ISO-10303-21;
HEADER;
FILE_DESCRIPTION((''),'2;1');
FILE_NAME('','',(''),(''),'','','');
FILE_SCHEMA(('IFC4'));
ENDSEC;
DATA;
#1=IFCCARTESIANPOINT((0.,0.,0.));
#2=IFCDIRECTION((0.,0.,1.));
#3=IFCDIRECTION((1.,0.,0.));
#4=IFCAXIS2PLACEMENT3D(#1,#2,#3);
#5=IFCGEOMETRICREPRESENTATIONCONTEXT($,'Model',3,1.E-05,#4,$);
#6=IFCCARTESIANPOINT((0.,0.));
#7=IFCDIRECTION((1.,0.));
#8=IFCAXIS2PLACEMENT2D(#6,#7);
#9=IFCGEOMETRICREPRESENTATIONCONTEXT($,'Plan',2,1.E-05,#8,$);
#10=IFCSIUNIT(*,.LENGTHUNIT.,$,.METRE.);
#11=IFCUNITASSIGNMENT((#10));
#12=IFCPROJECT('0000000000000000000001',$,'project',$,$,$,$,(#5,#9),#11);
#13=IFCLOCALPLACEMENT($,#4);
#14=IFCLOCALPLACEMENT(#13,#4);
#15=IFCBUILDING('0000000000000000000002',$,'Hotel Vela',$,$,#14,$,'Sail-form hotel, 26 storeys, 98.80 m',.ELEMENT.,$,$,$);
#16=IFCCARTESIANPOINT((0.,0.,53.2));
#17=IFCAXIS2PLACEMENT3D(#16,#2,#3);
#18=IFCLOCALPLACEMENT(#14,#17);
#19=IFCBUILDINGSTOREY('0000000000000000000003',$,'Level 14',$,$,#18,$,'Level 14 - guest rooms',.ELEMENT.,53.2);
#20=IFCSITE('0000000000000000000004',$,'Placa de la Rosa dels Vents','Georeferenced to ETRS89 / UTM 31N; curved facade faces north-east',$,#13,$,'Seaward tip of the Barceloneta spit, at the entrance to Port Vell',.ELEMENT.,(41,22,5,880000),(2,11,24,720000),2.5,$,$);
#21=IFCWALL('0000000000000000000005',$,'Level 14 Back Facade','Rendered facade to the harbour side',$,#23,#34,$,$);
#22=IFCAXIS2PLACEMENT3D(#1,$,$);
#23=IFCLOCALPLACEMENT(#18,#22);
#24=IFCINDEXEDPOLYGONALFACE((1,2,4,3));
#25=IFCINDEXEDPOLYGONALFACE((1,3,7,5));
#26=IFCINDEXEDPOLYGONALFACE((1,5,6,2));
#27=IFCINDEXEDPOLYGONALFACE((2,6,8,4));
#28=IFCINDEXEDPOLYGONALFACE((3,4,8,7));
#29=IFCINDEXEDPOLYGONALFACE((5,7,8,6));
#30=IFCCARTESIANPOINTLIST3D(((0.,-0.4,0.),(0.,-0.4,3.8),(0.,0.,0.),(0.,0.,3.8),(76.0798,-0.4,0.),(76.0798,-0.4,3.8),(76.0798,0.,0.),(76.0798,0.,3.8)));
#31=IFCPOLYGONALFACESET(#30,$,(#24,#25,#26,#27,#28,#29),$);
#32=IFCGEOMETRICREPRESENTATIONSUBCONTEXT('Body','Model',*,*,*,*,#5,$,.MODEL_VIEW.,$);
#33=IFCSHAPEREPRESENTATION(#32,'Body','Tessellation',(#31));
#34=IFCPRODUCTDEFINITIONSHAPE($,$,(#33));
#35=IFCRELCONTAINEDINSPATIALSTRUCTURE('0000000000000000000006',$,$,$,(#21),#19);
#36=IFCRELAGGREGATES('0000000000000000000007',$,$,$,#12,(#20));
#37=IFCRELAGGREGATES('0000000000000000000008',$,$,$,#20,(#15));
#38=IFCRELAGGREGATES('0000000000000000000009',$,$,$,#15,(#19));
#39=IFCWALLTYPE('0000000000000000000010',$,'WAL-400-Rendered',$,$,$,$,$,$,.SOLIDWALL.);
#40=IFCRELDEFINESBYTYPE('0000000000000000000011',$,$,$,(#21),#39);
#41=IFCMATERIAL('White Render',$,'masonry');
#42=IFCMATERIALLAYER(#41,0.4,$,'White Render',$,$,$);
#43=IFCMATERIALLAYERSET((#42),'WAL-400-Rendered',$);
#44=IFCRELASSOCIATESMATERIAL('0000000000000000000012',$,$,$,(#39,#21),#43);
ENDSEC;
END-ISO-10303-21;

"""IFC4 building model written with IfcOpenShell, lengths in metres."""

from ifc_helpers import new_model, si_unit, frame, origin_with_axes, origin_2d_with_axis, place, context, subcontext, project, spatial, line, indexed_curve, outline, extrude, material, layer, layer_set, layer_usage, type_object, element, save


model = new_model("IFC4")

# Units and contexts
model_context = context("Model", 3, precision=1e-05, world=origin_with_axes())
plan_context = context("Plan", 2, precision=1e-05, world=origin_2d_with_axis())
body_context = subcontext(model_context, "Body", "Model", "MODEL_VIEW")
ifc_project = project(units=[si_unit("LENGTHUNIT", "METRE")], contexts=[model_context, plan_context])

# Site, building, storey
site_placement = place(None, origin_with_axes())
site = spatial("IfcSite", under=ifc_project, at=site_placement, Name="Placa de la Rosa dels Vents", Description="Georeferenced to ETRS89 / UTM 31N; curved facade faces north-east", LongName="Seaward tip of the Barceloneta spit, at the entrance to Port Vell", CompositionType="ELEMENT", RefLatitude=(41, 22, 5, 880000), RefLongitude=(2, 11, 24, 720000), RefElevation=2.5)
building_placement = place(site_placement, origin_with_axes())
building = spatial("IfcBuilding", under=site, at=building_placement, Name="Hotel Vela", LongName="Sail-form hotel, 26 storeys, 98.80 m", CompositionType="ELEMENT")
storey_placement = place(building_placement, frame((0.0, 0.0, 53.2), z_axis=(0.0, 0.0, 1.0), x_axis=(1.0, 0.0, 0.0)))
storey = spatial("IfcBuildingStorey", under=building, at=storey_placement, Name="Level 14", LongName="Level 14 - guest rooms", CompositionType="ELEMENT", Elevation=53.2)

# Wall
ifc_material_1 = material(Name="White Render", Category="masonry")
ifc_layer_1 = layer(ifc_material_1, 0.4, Name="White Render")
ifc_layer_set_1 = layer_set([ifc_layer_1], Name="WAL-400-Rendered")
ifc_layer_usage_1 = layer_usage(ifc_layer_set_1, "AXIS2", "POSITIVE", 0.0)
wall_type = type_object("IfcWallType", Name="WAL-400-Rendered", PredefinedType="SOLIDWALL", material=ifc_layer_set_1)
wall_placement = place(storey_placement, frame((0.0, -0.4, 0.0), z_axis=(0.0, 0.0, 1.0), x_axis=(1.0, 0.0, 0.0)))
element("IfcWall", 1, at=wall_placement, inside=storey, type_object=wall_type, material=ifc_layer_usage_1, Name="Level 14 Back Facade", Description="Rendered facade to the harbour side", context=body_context, shape_type="SweptSolid", body=[
    extrude(outline(indexed_curve([(0.0, 0.0), (76.0798, 0.0), (76.0798, 0.4), (0.0, 0.4)], segments=[line(1, 2, 3, 4, 1)])), origin_with_axes(), (0.0, 0.0, 1.0), 3.8),
])

save(model, "model.ifc")
